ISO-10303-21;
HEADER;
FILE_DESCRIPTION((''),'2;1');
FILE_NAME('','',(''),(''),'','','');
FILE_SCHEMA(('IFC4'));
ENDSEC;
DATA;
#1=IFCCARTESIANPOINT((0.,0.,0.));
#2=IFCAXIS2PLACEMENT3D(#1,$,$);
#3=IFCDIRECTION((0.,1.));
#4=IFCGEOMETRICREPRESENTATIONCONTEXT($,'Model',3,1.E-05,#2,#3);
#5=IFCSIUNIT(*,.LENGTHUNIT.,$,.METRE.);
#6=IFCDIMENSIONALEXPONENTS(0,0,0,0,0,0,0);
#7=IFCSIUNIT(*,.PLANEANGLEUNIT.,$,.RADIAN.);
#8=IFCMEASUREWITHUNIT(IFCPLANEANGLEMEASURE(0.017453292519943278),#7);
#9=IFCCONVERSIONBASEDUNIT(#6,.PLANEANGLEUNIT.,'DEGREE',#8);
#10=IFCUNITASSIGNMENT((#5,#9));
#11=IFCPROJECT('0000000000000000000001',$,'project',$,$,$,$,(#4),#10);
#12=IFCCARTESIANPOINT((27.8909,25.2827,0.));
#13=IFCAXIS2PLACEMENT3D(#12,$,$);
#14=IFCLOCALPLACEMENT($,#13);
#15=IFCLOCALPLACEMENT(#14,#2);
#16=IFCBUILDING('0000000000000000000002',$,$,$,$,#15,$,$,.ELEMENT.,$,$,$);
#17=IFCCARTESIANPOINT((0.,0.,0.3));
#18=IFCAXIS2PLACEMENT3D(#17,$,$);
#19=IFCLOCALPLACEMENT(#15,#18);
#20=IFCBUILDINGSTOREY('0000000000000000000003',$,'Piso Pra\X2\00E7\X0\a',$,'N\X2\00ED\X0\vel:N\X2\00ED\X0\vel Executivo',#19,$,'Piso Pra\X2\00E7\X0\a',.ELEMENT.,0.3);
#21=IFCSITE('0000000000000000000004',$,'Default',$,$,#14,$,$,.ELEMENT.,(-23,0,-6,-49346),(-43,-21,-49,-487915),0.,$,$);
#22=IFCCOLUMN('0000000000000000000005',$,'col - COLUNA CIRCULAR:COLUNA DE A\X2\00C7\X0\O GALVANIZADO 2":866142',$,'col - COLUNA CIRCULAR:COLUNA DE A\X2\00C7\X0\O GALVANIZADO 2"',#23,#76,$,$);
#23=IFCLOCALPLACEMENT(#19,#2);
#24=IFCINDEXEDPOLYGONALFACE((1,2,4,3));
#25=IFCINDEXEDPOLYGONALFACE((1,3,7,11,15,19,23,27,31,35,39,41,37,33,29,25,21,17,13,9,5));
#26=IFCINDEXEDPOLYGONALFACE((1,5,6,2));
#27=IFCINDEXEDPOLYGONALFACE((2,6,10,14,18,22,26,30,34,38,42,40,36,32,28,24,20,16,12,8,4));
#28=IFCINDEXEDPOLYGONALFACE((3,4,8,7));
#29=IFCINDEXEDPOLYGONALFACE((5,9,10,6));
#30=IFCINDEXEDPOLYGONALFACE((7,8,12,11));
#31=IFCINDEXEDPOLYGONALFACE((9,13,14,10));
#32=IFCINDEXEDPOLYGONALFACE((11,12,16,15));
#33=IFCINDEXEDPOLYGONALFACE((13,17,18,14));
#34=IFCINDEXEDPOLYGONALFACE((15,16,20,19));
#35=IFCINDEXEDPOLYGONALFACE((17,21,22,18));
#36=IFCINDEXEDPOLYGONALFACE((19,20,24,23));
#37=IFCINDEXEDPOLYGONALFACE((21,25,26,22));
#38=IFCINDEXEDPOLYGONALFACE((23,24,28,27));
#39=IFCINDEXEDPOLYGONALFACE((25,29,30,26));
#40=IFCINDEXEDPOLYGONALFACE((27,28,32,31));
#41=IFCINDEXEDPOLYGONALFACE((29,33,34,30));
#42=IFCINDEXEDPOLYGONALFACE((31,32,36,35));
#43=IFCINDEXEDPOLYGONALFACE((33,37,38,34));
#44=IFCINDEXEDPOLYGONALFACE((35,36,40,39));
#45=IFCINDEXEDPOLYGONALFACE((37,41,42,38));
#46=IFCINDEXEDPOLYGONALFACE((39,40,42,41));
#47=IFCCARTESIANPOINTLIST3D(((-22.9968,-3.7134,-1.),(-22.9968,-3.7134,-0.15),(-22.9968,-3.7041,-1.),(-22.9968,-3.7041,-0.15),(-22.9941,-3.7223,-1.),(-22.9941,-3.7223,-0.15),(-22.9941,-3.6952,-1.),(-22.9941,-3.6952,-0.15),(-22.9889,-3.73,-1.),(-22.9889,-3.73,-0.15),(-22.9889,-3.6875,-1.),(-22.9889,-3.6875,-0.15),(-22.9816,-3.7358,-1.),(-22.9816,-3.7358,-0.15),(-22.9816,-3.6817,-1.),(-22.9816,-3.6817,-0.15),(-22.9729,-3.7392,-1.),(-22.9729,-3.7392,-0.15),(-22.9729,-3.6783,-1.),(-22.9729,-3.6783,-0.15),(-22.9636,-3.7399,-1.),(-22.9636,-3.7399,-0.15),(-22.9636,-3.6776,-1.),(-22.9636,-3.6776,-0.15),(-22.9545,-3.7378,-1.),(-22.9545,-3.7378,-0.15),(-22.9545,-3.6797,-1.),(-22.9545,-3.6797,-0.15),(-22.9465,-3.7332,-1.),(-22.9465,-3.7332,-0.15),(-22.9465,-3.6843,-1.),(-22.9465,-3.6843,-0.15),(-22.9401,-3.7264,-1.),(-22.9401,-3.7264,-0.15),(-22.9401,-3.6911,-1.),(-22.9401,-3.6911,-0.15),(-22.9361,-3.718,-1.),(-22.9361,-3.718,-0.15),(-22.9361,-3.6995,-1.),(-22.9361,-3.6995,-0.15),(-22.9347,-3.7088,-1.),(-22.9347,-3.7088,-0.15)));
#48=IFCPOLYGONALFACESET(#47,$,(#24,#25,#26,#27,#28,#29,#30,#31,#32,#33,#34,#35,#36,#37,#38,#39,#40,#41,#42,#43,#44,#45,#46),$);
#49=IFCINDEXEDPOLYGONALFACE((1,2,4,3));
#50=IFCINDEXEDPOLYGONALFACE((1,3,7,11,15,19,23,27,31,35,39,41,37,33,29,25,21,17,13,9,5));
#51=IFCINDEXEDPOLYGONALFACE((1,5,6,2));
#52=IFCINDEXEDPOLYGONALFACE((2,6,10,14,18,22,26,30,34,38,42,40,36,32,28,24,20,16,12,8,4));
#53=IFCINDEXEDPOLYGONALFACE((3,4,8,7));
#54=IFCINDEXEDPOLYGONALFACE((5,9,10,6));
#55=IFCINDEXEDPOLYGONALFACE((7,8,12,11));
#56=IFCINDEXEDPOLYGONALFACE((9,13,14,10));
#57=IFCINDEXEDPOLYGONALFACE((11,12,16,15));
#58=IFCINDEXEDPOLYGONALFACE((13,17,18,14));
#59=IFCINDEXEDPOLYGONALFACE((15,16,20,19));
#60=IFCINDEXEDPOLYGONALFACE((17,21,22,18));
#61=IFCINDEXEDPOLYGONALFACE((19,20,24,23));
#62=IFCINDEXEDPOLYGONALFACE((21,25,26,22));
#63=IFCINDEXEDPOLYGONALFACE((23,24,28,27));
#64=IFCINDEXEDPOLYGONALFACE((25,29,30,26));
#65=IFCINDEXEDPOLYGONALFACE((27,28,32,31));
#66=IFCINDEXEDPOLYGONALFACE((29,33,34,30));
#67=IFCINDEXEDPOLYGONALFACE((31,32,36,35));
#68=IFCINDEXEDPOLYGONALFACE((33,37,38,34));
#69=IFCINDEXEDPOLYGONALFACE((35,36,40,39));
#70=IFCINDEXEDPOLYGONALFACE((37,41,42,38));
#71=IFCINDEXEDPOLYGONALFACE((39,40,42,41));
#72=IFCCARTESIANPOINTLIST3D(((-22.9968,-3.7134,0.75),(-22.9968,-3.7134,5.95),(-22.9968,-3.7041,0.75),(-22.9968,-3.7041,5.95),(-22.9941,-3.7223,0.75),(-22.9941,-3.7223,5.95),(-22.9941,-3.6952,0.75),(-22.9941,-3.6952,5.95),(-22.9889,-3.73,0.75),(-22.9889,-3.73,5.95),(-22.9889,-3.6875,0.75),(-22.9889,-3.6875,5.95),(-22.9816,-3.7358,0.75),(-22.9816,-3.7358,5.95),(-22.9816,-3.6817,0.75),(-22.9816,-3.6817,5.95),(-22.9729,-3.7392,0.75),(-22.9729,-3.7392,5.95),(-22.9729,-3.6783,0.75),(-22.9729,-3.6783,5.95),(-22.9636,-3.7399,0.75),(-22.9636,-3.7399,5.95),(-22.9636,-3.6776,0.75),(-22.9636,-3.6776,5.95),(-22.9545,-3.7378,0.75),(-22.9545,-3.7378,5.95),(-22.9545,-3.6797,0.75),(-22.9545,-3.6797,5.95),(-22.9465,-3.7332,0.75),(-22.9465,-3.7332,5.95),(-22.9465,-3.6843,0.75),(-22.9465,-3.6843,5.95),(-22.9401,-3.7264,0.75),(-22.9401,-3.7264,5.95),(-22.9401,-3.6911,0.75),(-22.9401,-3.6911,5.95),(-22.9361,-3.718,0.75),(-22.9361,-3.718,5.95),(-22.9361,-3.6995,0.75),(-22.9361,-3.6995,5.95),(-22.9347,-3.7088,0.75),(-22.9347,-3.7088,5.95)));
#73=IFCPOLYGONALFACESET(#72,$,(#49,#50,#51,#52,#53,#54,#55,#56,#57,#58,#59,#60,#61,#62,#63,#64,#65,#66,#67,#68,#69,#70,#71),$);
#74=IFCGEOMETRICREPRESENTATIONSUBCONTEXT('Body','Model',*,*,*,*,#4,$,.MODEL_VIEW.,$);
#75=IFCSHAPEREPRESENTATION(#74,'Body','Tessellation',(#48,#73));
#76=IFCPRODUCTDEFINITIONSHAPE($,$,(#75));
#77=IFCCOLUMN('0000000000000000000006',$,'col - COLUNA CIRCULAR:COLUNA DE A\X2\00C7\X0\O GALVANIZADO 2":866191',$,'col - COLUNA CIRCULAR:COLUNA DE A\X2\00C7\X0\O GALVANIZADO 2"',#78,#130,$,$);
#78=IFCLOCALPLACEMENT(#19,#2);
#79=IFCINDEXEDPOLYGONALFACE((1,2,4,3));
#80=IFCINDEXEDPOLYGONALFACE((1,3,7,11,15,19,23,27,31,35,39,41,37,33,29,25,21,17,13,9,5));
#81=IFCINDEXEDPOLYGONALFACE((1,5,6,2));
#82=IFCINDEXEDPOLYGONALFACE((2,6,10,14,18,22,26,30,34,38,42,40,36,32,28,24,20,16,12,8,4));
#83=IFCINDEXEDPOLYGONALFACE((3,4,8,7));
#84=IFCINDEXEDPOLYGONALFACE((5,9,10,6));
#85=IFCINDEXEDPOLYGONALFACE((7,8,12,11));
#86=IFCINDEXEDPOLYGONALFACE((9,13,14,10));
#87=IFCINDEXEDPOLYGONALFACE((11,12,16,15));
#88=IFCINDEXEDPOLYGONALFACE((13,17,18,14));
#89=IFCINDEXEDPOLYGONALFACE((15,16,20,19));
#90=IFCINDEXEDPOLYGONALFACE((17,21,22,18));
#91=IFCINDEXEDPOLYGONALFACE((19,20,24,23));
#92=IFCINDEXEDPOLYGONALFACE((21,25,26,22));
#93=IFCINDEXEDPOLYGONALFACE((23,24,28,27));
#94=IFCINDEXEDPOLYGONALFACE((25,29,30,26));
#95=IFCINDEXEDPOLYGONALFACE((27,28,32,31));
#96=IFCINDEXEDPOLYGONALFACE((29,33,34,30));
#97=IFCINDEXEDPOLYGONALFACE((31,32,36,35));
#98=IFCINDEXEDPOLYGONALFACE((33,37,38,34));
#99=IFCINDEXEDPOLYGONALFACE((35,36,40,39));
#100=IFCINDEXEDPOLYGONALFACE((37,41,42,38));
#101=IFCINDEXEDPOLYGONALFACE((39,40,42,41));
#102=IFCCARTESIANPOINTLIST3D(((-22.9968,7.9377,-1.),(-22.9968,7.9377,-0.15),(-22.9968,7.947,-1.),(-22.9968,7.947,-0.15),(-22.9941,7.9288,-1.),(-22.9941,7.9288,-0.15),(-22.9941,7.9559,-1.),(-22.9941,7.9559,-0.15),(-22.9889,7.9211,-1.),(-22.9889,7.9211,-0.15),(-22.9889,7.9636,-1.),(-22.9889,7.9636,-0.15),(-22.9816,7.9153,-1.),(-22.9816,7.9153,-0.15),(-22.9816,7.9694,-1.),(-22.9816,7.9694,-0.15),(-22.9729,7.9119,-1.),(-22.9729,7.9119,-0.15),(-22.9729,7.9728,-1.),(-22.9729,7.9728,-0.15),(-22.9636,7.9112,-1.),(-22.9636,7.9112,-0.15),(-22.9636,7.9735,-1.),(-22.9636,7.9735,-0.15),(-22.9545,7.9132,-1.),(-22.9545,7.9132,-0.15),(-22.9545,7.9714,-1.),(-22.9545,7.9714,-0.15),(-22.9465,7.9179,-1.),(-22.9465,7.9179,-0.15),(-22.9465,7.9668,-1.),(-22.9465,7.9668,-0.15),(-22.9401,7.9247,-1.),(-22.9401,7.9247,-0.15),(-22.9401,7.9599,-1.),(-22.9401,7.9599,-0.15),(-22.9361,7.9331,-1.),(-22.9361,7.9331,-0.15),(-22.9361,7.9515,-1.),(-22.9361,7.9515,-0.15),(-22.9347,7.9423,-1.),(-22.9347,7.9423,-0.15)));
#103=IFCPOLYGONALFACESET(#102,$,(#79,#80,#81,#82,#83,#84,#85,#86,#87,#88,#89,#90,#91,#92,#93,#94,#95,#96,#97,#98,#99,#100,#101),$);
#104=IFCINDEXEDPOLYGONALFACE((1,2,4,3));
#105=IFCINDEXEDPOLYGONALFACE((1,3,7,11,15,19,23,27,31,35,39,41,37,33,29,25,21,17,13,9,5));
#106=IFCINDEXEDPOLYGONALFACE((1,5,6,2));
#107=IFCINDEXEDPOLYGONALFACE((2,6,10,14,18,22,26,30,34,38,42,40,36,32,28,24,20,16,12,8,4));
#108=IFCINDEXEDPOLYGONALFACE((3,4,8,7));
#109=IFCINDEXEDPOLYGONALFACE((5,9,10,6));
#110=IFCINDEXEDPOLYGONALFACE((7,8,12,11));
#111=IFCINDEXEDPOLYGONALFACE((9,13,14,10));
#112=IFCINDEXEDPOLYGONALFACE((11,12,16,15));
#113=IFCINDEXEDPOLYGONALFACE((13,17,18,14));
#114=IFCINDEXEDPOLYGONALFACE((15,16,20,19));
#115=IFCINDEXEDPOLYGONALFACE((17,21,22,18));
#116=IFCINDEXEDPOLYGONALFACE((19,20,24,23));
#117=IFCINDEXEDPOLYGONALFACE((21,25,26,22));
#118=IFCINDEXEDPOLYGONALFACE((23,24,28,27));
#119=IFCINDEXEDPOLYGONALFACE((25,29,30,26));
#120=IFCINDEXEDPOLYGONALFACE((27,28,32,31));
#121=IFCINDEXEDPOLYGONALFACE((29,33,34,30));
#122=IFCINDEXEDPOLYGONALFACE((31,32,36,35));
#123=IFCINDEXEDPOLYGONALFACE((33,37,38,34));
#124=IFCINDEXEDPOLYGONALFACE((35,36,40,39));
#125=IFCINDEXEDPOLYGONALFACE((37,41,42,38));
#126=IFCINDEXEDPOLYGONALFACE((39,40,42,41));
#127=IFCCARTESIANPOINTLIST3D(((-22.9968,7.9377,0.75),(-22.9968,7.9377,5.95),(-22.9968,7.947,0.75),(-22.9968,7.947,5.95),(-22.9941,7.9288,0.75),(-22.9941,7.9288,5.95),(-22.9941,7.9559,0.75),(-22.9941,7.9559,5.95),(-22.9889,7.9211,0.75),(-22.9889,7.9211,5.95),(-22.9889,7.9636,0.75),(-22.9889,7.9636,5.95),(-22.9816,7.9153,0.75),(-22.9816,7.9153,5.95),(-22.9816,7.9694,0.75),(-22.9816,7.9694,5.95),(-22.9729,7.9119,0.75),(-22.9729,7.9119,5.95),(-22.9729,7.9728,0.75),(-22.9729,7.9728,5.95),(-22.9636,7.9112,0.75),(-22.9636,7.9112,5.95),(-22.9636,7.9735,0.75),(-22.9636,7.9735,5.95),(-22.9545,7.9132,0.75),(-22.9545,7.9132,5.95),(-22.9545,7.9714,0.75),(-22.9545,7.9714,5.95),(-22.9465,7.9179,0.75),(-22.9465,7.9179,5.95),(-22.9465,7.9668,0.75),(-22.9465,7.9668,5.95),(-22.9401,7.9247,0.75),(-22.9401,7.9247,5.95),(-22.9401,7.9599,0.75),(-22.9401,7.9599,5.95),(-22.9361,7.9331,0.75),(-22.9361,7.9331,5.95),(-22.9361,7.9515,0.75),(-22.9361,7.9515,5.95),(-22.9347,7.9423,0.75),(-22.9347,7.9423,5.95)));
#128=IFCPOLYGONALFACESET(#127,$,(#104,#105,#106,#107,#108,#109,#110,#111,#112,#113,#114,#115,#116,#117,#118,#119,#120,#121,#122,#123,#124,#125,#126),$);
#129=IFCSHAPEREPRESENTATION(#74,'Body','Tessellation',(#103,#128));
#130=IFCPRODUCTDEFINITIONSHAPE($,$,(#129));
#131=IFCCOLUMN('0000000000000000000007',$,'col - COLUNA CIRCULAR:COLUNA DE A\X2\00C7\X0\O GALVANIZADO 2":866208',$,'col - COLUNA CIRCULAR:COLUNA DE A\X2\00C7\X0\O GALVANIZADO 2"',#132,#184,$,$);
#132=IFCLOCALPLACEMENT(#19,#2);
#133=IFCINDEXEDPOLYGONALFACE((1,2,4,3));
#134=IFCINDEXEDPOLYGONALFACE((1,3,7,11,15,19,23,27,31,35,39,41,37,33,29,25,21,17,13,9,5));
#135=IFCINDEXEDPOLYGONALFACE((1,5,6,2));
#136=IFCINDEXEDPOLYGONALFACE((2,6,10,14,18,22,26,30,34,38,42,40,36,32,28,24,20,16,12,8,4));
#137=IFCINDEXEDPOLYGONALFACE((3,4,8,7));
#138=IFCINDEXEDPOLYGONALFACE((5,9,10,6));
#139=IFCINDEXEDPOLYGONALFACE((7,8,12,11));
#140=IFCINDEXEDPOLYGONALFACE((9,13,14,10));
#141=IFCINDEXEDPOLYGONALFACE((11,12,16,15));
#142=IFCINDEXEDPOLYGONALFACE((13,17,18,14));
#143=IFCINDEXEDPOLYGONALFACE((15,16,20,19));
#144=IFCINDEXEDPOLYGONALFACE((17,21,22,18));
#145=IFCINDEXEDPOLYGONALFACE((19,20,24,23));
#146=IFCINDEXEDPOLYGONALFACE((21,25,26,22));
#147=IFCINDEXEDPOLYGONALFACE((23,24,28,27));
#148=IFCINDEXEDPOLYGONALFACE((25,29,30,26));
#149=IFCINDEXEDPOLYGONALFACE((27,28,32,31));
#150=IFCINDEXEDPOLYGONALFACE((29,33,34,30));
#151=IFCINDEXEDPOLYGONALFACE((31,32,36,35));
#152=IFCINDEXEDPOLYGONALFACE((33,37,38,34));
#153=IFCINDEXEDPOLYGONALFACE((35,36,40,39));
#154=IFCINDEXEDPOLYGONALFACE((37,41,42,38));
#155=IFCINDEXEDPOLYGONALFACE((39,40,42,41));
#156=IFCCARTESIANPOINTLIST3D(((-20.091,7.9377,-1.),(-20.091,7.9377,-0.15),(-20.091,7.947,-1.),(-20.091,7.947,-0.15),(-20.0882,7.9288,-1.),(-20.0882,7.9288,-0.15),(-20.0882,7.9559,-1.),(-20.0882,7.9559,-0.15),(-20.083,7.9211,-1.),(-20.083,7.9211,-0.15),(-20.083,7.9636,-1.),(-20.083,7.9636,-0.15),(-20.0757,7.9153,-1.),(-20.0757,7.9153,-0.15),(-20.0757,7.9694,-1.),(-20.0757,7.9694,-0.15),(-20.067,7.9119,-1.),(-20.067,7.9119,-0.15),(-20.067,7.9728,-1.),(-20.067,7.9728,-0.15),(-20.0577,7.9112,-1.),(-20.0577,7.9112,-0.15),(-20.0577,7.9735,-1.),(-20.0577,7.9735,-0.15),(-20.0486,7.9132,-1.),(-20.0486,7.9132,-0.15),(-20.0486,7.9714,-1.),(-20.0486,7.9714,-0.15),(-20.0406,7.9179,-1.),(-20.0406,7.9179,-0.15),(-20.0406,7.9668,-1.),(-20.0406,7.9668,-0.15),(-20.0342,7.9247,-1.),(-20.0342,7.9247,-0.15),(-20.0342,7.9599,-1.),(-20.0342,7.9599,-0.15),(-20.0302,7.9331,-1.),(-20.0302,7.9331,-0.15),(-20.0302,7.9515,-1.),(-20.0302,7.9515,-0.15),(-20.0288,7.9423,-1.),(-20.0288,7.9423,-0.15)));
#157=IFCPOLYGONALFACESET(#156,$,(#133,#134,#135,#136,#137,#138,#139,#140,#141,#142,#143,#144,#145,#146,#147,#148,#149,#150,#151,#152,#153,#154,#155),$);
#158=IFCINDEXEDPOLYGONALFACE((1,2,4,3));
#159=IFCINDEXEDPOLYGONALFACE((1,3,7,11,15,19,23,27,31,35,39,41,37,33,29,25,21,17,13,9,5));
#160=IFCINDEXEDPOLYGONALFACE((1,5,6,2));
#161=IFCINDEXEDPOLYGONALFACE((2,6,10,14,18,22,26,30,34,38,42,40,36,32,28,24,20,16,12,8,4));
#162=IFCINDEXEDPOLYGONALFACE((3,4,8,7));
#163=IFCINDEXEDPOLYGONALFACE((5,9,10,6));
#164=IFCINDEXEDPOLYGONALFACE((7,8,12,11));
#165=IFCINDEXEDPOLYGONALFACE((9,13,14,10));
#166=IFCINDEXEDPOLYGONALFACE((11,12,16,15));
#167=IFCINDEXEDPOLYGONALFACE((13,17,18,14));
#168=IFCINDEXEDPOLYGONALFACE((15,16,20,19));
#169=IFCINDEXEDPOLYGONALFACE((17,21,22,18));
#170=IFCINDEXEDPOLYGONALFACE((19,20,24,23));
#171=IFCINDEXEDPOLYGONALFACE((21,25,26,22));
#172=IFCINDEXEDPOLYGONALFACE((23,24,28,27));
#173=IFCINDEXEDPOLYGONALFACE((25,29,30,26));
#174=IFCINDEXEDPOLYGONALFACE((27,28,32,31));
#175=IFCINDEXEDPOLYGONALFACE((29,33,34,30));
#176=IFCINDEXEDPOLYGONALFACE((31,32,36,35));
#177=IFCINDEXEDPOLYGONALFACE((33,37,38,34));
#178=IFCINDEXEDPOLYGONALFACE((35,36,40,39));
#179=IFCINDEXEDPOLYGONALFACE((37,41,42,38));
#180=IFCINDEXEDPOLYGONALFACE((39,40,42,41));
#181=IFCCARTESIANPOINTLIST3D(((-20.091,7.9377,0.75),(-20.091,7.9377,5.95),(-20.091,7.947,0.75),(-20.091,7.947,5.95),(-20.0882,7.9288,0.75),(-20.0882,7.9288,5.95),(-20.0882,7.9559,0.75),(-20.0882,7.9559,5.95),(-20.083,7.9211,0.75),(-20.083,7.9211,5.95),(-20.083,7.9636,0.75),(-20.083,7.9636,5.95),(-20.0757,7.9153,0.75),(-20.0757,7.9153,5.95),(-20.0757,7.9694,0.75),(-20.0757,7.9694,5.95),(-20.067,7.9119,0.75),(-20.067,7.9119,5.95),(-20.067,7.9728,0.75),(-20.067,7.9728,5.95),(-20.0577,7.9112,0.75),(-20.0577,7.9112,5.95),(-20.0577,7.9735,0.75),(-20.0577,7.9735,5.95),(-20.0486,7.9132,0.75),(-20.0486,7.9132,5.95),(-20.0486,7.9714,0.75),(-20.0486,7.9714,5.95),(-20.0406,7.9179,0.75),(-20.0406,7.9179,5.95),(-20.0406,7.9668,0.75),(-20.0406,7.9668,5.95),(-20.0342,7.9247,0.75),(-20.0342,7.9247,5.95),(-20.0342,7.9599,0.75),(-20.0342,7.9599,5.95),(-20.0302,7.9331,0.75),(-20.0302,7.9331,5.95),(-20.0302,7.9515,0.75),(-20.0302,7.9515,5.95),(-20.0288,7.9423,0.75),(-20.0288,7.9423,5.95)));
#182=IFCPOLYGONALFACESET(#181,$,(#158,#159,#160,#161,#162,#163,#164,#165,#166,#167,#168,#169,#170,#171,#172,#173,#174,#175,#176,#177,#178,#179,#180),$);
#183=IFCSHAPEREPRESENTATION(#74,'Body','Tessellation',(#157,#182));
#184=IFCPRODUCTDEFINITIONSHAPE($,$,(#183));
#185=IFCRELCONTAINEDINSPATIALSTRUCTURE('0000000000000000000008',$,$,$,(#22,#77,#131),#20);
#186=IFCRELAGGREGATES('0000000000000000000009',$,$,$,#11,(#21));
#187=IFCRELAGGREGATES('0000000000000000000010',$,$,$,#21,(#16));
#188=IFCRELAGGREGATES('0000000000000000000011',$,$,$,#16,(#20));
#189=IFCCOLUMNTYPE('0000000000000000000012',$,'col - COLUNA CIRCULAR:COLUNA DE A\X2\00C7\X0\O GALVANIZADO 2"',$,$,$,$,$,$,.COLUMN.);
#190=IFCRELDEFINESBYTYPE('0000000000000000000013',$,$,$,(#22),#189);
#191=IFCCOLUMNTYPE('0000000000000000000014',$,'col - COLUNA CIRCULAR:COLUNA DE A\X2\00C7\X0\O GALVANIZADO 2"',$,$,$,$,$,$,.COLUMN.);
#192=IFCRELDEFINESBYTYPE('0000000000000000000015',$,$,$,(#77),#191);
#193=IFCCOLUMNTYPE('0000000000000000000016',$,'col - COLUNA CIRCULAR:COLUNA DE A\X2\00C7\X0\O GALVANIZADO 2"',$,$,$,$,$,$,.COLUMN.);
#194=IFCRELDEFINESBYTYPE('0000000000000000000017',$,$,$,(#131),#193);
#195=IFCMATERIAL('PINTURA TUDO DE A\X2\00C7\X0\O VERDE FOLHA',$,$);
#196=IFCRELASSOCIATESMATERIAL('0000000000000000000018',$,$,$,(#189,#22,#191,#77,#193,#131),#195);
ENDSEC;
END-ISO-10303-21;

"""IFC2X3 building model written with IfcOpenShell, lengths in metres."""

from ifc_helpers import new_model, entity, si_unit, converted_unit, direction, frame, origin, origin_2d_with_axis, place, context, subcontext, project, spatial, circle, extrude, source, transform, mapped, material, type_object, type_shapes, element, save


model = new_model("IFC2X3")

# Units and contexts
model_context = context("Model", 3, precision=1e-05, world=origin(), true_north=direction((0.0, 1.0)))
body_context = subcontext(model_context, "Body", "Model", "MODEL_VIEW")
ifc_project = project(units=[si_unit("LENGTHUNIT", "METRE"), converted_unit("PLANEANGLEUNIT", "DEGREE", entity("IfcPlaneAngleMeasure", 0.017453292519943278), si_unit("PLANEANGLEUNIT", "RADIAN"), dimensions=[0, 0, 0, 0, 0, 0, 0])], contexts=[model_context])

# Site, building, storey
site_placement = place(None, frame((27.8909, 25.2827, 0.0)))
site = spatial("IfcSite", under=ifc_project, at=site_placement, Name="Default", CompositionType="ELEMENT", RefLatitude=(-23, 0, -6, -49346), RefLongitude=(-43, -21, -49, -487915), RefElevation=0.0)
building_placement = place(site_placement, origin())
building = spatial("IfcBuilding", under=site, at=building_placement, CompositionType="ELEMENT")
storey_placement = place(building_placement, frame((0.0, 0.0, 0.3)))
storey = spatial("IfcBuildingStorey", under=building, at=storey_placement, Name="Piso Praça", ObjectType="Nível:Nível Executivo", LongName="Piso Praça", CompositionType="ELEMENT", Elevation=0.3)

# Columns
ifc_material_1 = material(Name="PINTURA TUDO DE AÇO VERDE FOLHA")
column_type_1 = type_object("IfcColumnType", Name="col - COLUNA CIRCULAR:COLUNA DE AÇO GALVANIZADO 2\"", PredefinedType="COLUMN", material=ifc_material_1)
shared_shape_1 = source(origin(), body_context, "Body", "SweptSolid", [
    extrude(circle(Radius=0.0312, at=origin_2d_with_axis()), frame((-22.9659, -3.7088, -0.7)), (0.0, 0.0, 1.0), 0.85),
    extrude(circle(Radius=0.0312, at=origin_2d_with_axis()), frame((-22.9659, -3.7088, 1.05)), (0.0, 0.0, 1.0), 5.2),
])
type_shapes(column_type_1, [shared_shape_1])
column_1_placement = place(storey_placement, frame((0.0, 0.0, -0.3)))
element("IfcColumn", 1, at=column_1_placement, inside=storey, type_object=column_type_1, material=ifc_material_1, Name="col - COLUNA CIRCULAR:COLUNA DE AÇO GALVANIZADO 2\":866142", ObjectType="col - COLUNA CIRCULAR:COLUNA DE AÇO GALVANIZADO 2\"", context=body_context, shape_type="MappedRepresentation", body=[
    mapped(shared_shape_1, transform((0.0, 0.0, 0.0), scale=1.0)),
])
column_type_2 = type_object("IfcColumnType", Name="col - COLUNA CIRCULAR:COLUNA DE AÇO GALVANIZADO 2\"", PredefinedType="COLUMN", material=ifc_material_1)
shared_shape_2 = source(origin(), body_context, "Body", "SweptSolid", [
    extrude(circle(Radius=0.0312, at=origin_2d_with_axis()), frame((-22.9659, 7.9423, -0.7)), (0.0, 0.0, 1.0), 0.85),
    extrude(circle(Radius=0.0312, at=origin_2d_with_axis()), frame((-22.9659, 7.9423, 1.05)), (0.0, 0.0, 1.0), 5.2),
])
type_shapes(column_type_2, [shared_shape_2])
column_2_placement = place(storey_placement, frame((0.0, 0.0, -0.3)))
element("IfcColumn", 2, at=column_2_placement, inside=storey, type_object=column_type_2, material=ifc_material_1, Name="col - COLUNA CIRCULAR:COLUNA DE AÇO GALVANIZADO 2\":866191", ObjectType="col - COLUNA CIRCULAR:COLUNA DE AÇO GALVANIZADO 2\"", context=body_context, shape_type="MappedRepresentation", body=[
    mapped(shared_shape_2, transform((0.0, 0.0, 0.0), scale=1.0)),
])
column_type_3 = type_object("IfcColumnType", Name="col - COLUNA CIRCULAR:COLUNA DE AÇO GALVANIZADO 2\"", PredefinedType="COLUMN", material=ifc_material_1)
shared_shape_3 = source(origin(), body_context, "Body", "SweptSolid", [
    extrude(circle(Radius=0.0312, at=origin_2d_with_axis()), frame((-20.0601, 7.9423, -0.7)), (0.0, 0.0, 1.0), 0.85),
    extrude(circle(Radius=0.0312, at=origin_2d_with_axis()), frame((-20.0601, 7.9423, 1.05)), (0.0, 0.0, 1.0), 5.2),
])
type_shapes(column_type_3, [shared_shape_3])
column_3_placement = place(storey_placement, frame((0.0, 0.0, -0.3)))
element("IfcColumn", 3, at=column_3_placement, inside=storey, type_object=column_type_3, material=ifc_material_1, Name="col - COLUNA CIRCULAR:COLUNA DE AÇO GALVANIZADO 2\":866208", ObjectType="col - COLUNA CIRCULAR:COLUNA DE AÇO GALVANIZADO 2\"", context=body_context, shape_type="MappedRepresentation", body=[
    mapped(shared_shape_3, transform((0.0, 0.0, 0.0), scale=1.0)),
])

save(model, "model.ifc")
